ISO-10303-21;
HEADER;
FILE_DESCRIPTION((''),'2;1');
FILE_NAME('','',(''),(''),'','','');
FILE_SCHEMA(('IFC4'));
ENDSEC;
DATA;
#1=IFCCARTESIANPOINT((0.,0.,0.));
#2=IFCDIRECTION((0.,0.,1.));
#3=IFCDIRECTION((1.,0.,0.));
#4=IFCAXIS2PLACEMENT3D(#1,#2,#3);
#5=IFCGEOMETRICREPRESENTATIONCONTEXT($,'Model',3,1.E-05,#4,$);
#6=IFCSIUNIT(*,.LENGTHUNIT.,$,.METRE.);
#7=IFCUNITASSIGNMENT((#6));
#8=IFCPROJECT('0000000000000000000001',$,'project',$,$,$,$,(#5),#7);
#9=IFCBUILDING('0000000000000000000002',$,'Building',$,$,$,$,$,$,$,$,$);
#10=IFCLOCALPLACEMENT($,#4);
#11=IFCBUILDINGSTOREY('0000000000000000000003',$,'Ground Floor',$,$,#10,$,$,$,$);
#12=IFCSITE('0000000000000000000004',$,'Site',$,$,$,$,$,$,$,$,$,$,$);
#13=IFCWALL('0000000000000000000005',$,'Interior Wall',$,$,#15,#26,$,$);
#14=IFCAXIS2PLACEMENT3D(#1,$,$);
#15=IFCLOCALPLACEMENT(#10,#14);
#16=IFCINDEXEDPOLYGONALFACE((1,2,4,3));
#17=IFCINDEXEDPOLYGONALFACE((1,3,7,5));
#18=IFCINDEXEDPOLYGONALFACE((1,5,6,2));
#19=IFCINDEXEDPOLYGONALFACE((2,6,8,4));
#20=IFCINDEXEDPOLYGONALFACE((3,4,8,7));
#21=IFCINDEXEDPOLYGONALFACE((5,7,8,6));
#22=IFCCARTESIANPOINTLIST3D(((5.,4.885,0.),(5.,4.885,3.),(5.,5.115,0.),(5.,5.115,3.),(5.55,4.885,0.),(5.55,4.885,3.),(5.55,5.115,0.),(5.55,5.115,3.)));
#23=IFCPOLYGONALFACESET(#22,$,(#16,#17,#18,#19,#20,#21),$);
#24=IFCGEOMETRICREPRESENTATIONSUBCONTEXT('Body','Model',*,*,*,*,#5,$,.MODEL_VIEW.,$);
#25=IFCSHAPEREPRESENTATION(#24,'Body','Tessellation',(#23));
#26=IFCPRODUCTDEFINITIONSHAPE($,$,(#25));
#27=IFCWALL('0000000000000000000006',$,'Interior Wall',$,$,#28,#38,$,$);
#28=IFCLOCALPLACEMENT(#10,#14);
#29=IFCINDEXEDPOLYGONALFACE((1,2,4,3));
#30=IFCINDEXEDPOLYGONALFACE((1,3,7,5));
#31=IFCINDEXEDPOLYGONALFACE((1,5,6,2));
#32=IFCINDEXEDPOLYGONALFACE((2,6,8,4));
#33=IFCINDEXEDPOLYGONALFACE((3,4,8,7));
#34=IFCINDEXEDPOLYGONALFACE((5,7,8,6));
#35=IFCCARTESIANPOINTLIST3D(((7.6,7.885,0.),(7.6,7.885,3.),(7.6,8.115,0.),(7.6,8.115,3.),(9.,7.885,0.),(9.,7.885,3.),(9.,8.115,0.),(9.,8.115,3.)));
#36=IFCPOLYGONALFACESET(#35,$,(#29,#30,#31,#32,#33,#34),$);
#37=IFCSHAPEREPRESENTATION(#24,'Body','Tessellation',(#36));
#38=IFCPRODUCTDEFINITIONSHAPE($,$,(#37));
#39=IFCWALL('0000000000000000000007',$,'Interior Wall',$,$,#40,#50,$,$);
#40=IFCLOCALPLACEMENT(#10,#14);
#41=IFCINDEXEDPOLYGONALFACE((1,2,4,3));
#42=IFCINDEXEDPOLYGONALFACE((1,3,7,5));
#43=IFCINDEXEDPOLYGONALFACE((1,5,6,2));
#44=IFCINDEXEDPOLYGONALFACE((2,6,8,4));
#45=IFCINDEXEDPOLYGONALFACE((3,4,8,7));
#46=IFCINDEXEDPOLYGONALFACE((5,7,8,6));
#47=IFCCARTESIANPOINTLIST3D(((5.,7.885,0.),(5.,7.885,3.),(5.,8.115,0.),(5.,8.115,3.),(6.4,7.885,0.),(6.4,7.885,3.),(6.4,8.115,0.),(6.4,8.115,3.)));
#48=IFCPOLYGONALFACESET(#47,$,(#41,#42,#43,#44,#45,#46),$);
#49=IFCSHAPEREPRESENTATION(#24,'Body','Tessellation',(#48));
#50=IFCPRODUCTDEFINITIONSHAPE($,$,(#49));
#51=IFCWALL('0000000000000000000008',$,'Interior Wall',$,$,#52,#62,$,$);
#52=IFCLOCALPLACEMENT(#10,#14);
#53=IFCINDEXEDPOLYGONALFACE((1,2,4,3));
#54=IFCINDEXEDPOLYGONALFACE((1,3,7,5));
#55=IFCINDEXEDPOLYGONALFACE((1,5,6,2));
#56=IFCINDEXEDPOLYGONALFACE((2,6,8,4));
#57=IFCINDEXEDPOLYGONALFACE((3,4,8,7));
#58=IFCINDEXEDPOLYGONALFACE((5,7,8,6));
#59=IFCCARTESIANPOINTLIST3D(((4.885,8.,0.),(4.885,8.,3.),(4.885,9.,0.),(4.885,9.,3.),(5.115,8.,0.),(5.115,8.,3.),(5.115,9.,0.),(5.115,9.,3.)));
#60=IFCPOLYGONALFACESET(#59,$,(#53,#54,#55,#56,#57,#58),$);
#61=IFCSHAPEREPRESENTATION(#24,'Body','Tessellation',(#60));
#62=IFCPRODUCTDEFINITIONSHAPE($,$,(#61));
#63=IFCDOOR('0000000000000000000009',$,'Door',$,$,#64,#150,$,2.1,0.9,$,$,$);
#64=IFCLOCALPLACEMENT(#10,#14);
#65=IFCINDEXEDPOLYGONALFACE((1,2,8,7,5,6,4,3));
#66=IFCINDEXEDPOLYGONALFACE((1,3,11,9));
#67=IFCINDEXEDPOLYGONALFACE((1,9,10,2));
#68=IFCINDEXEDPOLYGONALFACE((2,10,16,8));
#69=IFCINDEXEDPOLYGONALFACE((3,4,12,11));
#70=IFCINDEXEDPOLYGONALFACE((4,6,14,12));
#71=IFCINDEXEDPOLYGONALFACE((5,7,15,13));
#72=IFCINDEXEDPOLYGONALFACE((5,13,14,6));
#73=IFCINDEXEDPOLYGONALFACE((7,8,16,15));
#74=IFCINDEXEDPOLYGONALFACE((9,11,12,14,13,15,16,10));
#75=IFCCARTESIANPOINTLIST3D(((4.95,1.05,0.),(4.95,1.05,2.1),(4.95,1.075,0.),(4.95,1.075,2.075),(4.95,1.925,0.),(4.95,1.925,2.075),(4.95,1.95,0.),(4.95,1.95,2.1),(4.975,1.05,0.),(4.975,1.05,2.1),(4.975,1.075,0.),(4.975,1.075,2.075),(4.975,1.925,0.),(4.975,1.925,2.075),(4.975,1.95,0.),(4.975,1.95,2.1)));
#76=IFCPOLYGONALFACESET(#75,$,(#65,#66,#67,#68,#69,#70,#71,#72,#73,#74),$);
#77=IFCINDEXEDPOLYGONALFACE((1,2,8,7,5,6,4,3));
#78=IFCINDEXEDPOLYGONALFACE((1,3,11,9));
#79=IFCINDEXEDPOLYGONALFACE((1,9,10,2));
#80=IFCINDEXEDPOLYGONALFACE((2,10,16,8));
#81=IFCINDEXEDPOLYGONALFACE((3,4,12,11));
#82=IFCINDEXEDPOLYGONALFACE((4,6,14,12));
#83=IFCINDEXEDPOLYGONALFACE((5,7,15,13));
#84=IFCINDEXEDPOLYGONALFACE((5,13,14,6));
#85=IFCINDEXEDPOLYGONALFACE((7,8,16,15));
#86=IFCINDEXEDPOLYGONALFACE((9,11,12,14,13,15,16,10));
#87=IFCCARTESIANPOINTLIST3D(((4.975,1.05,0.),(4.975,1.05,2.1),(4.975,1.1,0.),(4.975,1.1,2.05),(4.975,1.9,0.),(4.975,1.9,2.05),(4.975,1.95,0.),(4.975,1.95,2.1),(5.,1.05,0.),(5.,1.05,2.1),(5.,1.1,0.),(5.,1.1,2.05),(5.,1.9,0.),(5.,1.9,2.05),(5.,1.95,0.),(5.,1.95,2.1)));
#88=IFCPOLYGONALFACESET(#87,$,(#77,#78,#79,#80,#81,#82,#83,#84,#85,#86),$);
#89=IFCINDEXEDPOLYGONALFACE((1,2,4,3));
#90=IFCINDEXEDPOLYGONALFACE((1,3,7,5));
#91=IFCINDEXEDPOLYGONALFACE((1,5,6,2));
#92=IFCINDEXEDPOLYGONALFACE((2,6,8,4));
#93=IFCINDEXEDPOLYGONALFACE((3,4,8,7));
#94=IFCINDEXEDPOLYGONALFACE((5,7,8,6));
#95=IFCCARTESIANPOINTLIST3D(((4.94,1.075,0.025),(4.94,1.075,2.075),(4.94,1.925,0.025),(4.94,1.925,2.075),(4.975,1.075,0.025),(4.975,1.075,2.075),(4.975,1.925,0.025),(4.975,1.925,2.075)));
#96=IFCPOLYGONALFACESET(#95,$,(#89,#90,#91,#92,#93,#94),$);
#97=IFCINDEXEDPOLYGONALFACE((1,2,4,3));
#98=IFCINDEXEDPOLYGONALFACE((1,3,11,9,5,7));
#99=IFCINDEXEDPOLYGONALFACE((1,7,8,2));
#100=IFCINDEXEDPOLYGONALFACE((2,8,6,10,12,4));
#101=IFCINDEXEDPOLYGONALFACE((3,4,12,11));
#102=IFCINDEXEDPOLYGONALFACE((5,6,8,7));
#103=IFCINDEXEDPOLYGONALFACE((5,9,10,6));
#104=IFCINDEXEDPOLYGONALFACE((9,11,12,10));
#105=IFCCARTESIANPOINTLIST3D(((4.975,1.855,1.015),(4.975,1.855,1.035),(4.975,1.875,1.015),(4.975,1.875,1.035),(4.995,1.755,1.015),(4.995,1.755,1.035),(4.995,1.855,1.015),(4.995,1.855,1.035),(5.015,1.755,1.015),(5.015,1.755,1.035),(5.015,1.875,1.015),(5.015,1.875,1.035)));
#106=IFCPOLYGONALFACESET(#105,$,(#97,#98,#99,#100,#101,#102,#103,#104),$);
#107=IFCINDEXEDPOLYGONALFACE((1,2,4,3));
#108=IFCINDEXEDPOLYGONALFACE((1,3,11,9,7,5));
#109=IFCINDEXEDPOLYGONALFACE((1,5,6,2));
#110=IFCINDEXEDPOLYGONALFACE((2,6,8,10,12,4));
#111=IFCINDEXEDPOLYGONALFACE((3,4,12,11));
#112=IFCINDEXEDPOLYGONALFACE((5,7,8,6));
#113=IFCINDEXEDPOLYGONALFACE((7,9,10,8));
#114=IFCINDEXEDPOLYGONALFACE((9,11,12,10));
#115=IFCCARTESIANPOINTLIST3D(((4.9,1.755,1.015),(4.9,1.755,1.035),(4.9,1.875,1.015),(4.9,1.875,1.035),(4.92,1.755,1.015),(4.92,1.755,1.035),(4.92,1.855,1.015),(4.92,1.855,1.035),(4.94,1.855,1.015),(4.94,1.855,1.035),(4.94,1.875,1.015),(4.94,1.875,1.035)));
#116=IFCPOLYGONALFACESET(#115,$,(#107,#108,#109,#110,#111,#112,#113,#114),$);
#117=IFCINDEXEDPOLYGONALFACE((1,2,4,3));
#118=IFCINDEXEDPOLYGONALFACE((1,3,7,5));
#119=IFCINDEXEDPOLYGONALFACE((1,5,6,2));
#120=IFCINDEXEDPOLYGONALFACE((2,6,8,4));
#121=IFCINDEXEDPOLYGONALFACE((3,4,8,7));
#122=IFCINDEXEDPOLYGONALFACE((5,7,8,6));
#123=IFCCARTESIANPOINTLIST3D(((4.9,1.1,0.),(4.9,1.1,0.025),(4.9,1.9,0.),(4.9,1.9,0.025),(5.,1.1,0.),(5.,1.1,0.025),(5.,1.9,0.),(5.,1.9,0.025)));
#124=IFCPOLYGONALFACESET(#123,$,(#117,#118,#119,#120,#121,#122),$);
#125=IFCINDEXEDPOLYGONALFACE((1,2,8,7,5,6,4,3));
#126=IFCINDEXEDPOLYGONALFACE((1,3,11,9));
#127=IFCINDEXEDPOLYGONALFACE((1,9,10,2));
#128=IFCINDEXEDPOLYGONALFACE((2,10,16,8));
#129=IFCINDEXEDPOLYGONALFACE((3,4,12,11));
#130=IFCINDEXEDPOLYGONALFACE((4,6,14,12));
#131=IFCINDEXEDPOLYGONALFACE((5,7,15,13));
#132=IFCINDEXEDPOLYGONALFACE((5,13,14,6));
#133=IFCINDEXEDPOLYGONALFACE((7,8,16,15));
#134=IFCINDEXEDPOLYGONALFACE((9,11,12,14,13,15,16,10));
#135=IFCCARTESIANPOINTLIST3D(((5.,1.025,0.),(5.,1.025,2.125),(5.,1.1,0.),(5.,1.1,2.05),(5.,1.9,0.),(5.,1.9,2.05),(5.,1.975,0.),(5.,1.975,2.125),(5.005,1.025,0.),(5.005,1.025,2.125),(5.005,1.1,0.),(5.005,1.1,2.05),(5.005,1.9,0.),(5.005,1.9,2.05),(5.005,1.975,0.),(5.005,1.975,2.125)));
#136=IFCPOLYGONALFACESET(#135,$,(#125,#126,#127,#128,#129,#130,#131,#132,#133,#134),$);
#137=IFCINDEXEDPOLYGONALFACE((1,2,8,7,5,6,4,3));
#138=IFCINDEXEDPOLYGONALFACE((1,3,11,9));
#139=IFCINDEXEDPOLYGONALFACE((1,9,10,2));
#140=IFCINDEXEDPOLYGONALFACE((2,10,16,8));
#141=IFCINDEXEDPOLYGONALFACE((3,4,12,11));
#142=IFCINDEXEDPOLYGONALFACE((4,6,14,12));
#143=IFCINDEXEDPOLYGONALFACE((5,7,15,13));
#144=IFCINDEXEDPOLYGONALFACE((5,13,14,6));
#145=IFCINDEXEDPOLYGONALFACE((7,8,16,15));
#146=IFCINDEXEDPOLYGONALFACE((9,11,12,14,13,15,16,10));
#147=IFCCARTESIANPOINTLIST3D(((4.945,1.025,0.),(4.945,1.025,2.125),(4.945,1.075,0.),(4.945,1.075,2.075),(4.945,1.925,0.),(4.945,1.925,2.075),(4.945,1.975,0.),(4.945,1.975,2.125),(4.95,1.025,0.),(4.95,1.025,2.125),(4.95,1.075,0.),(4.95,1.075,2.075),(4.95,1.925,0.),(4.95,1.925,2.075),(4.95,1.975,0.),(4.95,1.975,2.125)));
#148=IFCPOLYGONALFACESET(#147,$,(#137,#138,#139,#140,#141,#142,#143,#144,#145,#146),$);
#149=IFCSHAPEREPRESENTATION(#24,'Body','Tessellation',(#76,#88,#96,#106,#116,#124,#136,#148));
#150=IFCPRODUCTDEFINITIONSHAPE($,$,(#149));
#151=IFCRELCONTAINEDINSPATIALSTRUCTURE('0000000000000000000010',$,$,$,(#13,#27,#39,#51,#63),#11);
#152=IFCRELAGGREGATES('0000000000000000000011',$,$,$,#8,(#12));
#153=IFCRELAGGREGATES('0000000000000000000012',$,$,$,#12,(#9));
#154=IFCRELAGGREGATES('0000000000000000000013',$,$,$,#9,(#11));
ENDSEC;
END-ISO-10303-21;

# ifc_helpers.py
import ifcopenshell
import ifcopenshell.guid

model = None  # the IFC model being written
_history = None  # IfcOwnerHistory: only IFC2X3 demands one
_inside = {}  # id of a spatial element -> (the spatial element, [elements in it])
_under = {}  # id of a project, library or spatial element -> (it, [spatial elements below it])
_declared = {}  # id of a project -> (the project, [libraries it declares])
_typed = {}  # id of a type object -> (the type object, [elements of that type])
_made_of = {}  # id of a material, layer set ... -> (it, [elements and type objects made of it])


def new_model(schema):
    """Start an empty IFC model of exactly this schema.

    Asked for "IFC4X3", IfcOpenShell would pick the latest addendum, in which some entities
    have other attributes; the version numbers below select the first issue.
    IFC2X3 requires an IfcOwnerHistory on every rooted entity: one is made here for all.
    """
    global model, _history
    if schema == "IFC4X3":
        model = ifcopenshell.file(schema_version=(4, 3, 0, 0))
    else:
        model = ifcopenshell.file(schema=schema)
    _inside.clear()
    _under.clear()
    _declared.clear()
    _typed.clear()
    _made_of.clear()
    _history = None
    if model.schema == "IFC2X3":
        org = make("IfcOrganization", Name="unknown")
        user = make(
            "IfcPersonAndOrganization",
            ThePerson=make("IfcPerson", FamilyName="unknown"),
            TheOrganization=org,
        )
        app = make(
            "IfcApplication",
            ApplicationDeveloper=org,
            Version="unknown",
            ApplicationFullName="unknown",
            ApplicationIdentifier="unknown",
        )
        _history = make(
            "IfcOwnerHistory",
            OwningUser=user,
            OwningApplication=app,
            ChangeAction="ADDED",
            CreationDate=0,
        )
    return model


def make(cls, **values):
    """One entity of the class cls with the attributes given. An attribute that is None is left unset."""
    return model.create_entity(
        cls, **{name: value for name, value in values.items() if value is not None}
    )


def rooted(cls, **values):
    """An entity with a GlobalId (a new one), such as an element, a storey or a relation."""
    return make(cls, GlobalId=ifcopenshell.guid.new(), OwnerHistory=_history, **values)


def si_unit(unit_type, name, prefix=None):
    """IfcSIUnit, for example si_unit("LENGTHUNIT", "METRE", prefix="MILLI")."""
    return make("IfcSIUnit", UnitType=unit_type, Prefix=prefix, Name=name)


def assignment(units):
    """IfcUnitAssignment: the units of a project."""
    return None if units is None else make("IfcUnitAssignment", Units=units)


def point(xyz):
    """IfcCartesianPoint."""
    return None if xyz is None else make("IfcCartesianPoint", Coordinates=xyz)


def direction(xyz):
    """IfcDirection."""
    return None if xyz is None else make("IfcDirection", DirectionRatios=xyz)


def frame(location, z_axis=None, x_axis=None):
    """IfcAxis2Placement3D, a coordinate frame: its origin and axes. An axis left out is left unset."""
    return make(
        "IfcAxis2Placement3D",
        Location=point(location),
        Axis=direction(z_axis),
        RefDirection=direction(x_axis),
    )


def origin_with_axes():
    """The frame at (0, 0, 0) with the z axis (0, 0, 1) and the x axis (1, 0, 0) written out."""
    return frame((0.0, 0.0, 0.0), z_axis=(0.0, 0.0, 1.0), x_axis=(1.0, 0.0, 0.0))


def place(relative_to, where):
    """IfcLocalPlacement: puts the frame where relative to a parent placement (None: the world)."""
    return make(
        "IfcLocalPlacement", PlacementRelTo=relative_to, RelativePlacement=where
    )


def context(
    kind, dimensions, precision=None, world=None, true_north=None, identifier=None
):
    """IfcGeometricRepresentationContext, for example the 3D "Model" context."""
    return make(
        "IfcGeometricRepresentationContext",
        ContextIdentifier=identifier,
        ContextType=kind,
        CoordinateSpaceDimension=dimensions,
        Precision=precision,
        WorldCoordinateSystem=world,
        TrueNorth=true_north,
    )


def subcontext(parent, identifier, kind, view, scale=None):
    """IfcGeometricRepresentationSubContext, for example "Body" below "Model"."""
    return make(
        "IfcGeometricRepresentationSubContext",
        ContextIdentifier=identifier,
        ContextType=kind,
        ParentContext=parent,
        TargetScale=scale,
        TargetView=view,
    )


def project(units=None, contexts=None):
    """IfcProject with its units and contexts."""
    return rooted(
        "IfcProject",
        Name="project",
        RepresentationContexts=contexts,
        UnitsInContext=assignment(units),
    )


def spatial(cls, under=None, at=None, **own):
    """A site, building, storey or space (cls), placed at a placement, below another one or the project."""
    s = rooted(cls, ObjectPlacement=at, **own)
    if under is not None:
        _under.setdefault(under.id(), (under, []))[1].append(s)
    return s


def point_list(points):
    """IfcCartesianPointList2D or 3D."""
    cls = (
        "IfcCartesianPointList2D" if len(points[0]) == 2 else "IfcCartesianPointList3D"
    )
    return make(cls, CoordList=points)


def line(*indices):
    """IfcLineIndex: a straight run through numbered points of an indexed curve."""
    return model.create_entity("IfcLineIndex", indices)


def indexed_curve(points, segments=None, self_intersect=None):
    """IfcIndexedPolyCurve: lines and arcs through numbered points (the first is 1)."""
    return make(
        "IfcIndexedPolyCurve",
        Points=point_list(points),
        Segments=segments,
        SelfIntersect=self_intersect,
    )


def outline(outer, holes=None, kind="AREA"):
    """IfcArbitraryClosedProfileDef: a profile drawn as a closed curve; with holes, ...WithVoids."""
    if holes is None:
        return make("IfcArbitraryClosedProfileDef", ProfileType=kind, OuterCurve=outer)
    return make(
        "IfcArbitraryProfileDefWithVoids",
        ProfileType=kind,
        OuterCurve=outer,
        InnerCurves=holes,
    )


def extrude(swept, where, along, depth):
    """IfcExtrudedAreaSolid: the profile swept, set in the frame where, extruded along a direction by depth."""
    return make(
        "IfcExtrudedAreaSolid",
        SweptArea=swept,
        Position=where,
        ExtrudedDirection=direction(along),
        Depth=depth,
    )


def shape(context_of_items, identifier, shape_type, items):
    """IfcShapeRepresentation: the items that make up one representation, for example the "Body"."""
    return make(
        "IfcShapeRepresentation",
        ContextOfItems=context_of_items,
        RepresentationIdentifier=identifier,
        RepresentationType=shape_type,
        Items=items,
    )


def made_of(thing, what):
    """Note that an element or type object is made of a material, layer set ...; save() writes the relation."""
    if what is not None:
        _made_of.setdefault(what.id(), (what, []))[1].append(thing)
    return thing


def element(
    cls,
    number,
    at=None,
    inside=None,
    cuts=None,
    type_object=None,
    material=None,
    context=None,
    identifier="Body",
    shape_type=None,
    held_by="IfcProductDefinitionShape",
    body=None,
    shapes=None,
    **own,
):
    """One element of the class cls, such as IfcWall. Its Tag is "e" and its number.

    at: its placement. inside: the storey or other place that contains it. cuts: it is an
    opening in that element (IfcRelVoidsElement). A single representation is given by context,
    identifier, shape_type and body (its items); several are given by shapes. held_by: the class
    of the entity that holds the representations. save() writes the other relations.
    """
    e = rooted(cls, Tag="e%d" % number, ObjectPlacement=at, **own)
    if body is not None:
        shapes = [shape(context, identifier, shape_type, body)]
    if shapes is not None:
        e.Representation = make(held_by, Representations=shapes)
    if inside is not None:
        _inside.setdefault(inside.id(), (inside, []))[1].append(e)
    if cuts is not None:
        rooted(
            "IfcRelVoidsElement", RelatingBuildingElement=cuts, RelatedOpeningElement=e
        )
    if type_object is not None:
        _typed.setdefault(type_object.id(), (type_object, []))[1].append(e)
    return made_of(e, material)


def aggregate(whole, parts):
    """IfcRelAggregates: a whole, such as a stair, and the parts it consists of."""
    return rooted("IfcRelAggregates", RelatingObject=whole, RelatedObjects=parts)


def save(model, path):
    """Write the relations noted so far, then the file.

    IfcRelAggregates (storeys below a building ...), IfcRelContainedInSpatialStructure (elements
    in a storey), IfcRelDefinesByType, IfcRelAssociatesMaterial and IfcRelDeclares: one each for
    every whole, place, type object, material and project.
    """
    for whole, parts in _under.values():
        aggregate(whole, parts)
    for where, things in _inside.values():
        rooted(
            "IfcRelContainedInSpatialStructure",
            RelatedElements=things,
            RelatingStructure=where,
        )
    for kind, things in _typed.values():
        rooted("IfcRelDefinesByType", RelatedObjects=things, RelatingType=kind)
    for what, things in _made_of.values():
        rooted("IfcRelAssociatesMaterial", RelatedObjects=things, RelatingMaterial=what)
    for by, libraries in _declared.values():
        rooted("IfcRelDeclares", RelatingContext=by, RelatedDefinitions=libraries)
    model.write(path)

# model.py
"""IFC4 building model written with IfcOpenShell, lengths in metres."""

from ifc_helpers import new_model, si_unit, frame, origin_with_axes, place, context, subcontext, project, spatial, line, indexed_curve, outline, extrude, element, save


model = new_model("IFC4")

# Units and contexts
model_context = context("Model", 3, precision=1e-05, world=origin_with_axes())
body_context = subcontext(model_context, "Body", "Model", "MODEL_VIEW")
ifc_project = project(units=[si_unit("LENGTHUNIT", "METRE")], contexts=[model_context])

# Site, building, storey
site = spatial("IfcSite", under=ifc_project, Name="Site")
building = spatial("IfcBuilding", under=site, Name="Building")
storey_placement = place(None, origin_with_axes())
storey = spatial("IfcBuildingStorey", under=building, at=storey_placement, Name="Ground Floor")

# Walls
for number, where, z_axis, x_axis, name in (
    (1, (5.55, 5.0, 0.0), (0.0, 0.0, 1.0), (-1.0, 0.0, 0.0), "Interior Wall"),
):
    element("IfcWall", number, at=place(storey_placement, frame(where, z_axis=z_axis, x_axis=x_axis)), inside=storey, Name=name, context=body_context, shape_type="SweptSolid", body=[
        extrude(outline(indexed_curve([(0.0, 0.0), (0.0, 0.23), (0.55, 0.23), (0.55, 0.0), (0.0, 0.0)], self_intersect=False)), frame((0.0, -0.115, 0.0), z_axis=(0.0, 0.0, 1.0), x_axis=(1.0, 0.0, 0.0)), (0.0, 0.0, 1.0), 3.0),
    ])
for number, where, z_axis, x_axis, name in (
    (2, (9.0, 8.0, 0.0), (0.0, 0.0, 1.0), (-1.0, 0.0, 0.0), "Interior Wall"),
    (3, (6.4, 8.0, 0.0), (0.0, 0.0, 1.0), (-1.0, 0.0, 0.0), "Interior Wall"),
):
    element("IfcWall", number, at=place(storey_placement, frame(where, z_axis=z_axis, x_axis=x_axis)), inside=storey, Name=name, context=body_context, shape_type="SweptSolid", body=[
        extrude(outline(indexed_curve([(0.0, 0.0), (0.0, 0.23), (1.4, 0.23), (1.4, 0.0), (0.0, 0.0)], self_intersect=False)), frame((0.0, -0.115, 0.0), z_axis=(0.0, 0.0, 1.0), x_axis=(1.0, 0.0, 0.0)), (0.0, 0.0, 1.0), 3.0),
    ])
wall_1_placement = place(storey_placement, frame((5.0, 8.0, 0.0), z_axis=(0.0, 0.0, 1.0), x_axis=(0.0, 1.0, 0.0)))
element("IfcWall", 4, at=wall_1_placement, inside=storey, Name="Interior Wall", context=body_context, shape_type="SweptSolid", body=[
    extrude(outline(indexed_curve([(0.0, 0.0), (0.0, 0.23), (1.0, 0.23), (1.0, 0.0), (0.0, 0.0)], self_intersect=False)), frame((0.0, -0.115, 0.0), z_axis=(0.0, 0.0, 1.0), x_axis=(1.0, 0.0, 0.0)), (0.0, 0.0, 1.0), 3.0),
])

# Door
door_1_placement = place(storey_placement, frame((5.0, 1.05, 0.0), z_axis=(0.0, 0.0, 1.0), x_axis=(0.0, 1.0, 0.0)))
element("IfcDoor", 5, at=door_1_placement, inside=storey, Name="Door", OverallHeight=2.1, OverallWidth=0.9, context=body_context, shape_type="SweptSolid", body=[
    extrude(outline(indexed_curve([(0.0, 0.0), (0.0, 2.1), (0.9, 2.1), (0.9, 0.0), (0.875, 0.0), (0.875, 2.075), (0.025, 2.075), (0.025, 0.0)], segments=[line(1, 2, 3, 4, 5, 6, 7, 8, 1)])), frame((0.0, 0.025, 0.0), z_axis=(0.0, -1.0, 0.0), x_axis=(1.0, 0.0, 0.0)), (0.0, 0.0, -1.0), 0.025),
    extrude(outline(indexed_curve([(0.0, 0.0), (0.0, 2.1), (0.9, 2.1), (0.9, 0.0), (0.85, 0.0), (0.85, 2.05), (0.05, 2.05), (0.05, 0.0)], segments=[line(1, 2, 3, 4, 5, 6, 7, 8, 1)])), frame((0.0, 0.0, 0.0), z_axis=(0.0, -1.0, 0.0), x_axis=(1.0, 0.0, 0.0)), (0.0, 0.0, -1.0), 0.025),
    extrude(outline(indexed_curve([(0.0, 0.0), (0.85, 0.0), (0.85, 0.035), (0.0, 0.035)], segments=[line(1, 2, 3, 4, 1)])), frame((0.025, 0.025, 0.025), z_axis=(0.0, 0.0, 1.0), x_axis=(1.0, 0.0, 0.0)), (0.0, 0.0, 1.0), 2.05),
    extrude(outline(indexed_curve([(0.0, 0.0), (0.0, -0.04), (-0.12, -0.04), (-0.12, -0.02), (-0.02, -0.02), (-0.02, 0.0)], segments=[line(1, 2, 3, 4, 5, 6, 1)])), frame((0.825, 0.025, 1.015), z_axis=(0.0, 0.0, 1.0), x_axis=(1.0, 0.0, 0.0)), (0.0, 0.0, 1.0), 0.02),
    extrude(outline(indexed_curve([(0.0, 0.0), (0.0, 0.04), (-0.12, 0.04), (-0.12, 0.02), (-0.02, 0.02), (-0.02, 0.0)], segments=[line(1, 2, 3, 4, 5, 6, 1)])), frame((0.825, 0.06, 1.015), z_axis=(0.0, 0.0, 1.0), x_axis=(1.0, 0.0, 0.0)), (0.0, 0.0, 1.0), 0.02),
    extrude(outline(indexed_curve([(0.0, 0.0), (0.8, 0.0), (0.8, 0.1), (0.0, 0.1)], segments=[line(1, 2, 3, 4, 1)])), frame((0.05, 0.0, 0.0), z_axis=(0.0, 0.0, 1.0), x_axis=(1.0, 0.0, 0.0)), (0.0, 0.0, 1.0), 0.025),
    extrude(outline(indexed_curve([(0.0, 0.0), (0.0, 2.125), (0.95, 2.125), (0.95, 0.0), (0.875, 0.0), (0.875, 2.05), (0.075, 2.05), (0.075, 0.0)], segments=[line(1, 2, 3, 4, 5, 6, 7, 8, 1)])), frame((-0.025, -0.005, 0.0), z_axis=(0.0, -1.0, 0.0), x_axis=(1.0, 0.0, 0.0)), (0.0, 0.0, -1.0), 0.005),
    extrude(outline(indexed_curve([(0.0, 0.0), (0.0, 2.125), (0.95, 2.125), (0.95, 0.0), (0.9, 0.0), (0.9, 2.075), (0.05, 2.075), (0.05, 0.0)], segments=[line(1, 2, 3, 4, 5, 6, 7, 8, 1)])), frame((-0.025, 0.05, 0.0), z_axis=(0.0, -1.0, 0.0), x_axis=(1.0, 0.0, 0.0)), (0.0, 0.0, -1.0), 0.005),
])

save(model, "model.ifc")
